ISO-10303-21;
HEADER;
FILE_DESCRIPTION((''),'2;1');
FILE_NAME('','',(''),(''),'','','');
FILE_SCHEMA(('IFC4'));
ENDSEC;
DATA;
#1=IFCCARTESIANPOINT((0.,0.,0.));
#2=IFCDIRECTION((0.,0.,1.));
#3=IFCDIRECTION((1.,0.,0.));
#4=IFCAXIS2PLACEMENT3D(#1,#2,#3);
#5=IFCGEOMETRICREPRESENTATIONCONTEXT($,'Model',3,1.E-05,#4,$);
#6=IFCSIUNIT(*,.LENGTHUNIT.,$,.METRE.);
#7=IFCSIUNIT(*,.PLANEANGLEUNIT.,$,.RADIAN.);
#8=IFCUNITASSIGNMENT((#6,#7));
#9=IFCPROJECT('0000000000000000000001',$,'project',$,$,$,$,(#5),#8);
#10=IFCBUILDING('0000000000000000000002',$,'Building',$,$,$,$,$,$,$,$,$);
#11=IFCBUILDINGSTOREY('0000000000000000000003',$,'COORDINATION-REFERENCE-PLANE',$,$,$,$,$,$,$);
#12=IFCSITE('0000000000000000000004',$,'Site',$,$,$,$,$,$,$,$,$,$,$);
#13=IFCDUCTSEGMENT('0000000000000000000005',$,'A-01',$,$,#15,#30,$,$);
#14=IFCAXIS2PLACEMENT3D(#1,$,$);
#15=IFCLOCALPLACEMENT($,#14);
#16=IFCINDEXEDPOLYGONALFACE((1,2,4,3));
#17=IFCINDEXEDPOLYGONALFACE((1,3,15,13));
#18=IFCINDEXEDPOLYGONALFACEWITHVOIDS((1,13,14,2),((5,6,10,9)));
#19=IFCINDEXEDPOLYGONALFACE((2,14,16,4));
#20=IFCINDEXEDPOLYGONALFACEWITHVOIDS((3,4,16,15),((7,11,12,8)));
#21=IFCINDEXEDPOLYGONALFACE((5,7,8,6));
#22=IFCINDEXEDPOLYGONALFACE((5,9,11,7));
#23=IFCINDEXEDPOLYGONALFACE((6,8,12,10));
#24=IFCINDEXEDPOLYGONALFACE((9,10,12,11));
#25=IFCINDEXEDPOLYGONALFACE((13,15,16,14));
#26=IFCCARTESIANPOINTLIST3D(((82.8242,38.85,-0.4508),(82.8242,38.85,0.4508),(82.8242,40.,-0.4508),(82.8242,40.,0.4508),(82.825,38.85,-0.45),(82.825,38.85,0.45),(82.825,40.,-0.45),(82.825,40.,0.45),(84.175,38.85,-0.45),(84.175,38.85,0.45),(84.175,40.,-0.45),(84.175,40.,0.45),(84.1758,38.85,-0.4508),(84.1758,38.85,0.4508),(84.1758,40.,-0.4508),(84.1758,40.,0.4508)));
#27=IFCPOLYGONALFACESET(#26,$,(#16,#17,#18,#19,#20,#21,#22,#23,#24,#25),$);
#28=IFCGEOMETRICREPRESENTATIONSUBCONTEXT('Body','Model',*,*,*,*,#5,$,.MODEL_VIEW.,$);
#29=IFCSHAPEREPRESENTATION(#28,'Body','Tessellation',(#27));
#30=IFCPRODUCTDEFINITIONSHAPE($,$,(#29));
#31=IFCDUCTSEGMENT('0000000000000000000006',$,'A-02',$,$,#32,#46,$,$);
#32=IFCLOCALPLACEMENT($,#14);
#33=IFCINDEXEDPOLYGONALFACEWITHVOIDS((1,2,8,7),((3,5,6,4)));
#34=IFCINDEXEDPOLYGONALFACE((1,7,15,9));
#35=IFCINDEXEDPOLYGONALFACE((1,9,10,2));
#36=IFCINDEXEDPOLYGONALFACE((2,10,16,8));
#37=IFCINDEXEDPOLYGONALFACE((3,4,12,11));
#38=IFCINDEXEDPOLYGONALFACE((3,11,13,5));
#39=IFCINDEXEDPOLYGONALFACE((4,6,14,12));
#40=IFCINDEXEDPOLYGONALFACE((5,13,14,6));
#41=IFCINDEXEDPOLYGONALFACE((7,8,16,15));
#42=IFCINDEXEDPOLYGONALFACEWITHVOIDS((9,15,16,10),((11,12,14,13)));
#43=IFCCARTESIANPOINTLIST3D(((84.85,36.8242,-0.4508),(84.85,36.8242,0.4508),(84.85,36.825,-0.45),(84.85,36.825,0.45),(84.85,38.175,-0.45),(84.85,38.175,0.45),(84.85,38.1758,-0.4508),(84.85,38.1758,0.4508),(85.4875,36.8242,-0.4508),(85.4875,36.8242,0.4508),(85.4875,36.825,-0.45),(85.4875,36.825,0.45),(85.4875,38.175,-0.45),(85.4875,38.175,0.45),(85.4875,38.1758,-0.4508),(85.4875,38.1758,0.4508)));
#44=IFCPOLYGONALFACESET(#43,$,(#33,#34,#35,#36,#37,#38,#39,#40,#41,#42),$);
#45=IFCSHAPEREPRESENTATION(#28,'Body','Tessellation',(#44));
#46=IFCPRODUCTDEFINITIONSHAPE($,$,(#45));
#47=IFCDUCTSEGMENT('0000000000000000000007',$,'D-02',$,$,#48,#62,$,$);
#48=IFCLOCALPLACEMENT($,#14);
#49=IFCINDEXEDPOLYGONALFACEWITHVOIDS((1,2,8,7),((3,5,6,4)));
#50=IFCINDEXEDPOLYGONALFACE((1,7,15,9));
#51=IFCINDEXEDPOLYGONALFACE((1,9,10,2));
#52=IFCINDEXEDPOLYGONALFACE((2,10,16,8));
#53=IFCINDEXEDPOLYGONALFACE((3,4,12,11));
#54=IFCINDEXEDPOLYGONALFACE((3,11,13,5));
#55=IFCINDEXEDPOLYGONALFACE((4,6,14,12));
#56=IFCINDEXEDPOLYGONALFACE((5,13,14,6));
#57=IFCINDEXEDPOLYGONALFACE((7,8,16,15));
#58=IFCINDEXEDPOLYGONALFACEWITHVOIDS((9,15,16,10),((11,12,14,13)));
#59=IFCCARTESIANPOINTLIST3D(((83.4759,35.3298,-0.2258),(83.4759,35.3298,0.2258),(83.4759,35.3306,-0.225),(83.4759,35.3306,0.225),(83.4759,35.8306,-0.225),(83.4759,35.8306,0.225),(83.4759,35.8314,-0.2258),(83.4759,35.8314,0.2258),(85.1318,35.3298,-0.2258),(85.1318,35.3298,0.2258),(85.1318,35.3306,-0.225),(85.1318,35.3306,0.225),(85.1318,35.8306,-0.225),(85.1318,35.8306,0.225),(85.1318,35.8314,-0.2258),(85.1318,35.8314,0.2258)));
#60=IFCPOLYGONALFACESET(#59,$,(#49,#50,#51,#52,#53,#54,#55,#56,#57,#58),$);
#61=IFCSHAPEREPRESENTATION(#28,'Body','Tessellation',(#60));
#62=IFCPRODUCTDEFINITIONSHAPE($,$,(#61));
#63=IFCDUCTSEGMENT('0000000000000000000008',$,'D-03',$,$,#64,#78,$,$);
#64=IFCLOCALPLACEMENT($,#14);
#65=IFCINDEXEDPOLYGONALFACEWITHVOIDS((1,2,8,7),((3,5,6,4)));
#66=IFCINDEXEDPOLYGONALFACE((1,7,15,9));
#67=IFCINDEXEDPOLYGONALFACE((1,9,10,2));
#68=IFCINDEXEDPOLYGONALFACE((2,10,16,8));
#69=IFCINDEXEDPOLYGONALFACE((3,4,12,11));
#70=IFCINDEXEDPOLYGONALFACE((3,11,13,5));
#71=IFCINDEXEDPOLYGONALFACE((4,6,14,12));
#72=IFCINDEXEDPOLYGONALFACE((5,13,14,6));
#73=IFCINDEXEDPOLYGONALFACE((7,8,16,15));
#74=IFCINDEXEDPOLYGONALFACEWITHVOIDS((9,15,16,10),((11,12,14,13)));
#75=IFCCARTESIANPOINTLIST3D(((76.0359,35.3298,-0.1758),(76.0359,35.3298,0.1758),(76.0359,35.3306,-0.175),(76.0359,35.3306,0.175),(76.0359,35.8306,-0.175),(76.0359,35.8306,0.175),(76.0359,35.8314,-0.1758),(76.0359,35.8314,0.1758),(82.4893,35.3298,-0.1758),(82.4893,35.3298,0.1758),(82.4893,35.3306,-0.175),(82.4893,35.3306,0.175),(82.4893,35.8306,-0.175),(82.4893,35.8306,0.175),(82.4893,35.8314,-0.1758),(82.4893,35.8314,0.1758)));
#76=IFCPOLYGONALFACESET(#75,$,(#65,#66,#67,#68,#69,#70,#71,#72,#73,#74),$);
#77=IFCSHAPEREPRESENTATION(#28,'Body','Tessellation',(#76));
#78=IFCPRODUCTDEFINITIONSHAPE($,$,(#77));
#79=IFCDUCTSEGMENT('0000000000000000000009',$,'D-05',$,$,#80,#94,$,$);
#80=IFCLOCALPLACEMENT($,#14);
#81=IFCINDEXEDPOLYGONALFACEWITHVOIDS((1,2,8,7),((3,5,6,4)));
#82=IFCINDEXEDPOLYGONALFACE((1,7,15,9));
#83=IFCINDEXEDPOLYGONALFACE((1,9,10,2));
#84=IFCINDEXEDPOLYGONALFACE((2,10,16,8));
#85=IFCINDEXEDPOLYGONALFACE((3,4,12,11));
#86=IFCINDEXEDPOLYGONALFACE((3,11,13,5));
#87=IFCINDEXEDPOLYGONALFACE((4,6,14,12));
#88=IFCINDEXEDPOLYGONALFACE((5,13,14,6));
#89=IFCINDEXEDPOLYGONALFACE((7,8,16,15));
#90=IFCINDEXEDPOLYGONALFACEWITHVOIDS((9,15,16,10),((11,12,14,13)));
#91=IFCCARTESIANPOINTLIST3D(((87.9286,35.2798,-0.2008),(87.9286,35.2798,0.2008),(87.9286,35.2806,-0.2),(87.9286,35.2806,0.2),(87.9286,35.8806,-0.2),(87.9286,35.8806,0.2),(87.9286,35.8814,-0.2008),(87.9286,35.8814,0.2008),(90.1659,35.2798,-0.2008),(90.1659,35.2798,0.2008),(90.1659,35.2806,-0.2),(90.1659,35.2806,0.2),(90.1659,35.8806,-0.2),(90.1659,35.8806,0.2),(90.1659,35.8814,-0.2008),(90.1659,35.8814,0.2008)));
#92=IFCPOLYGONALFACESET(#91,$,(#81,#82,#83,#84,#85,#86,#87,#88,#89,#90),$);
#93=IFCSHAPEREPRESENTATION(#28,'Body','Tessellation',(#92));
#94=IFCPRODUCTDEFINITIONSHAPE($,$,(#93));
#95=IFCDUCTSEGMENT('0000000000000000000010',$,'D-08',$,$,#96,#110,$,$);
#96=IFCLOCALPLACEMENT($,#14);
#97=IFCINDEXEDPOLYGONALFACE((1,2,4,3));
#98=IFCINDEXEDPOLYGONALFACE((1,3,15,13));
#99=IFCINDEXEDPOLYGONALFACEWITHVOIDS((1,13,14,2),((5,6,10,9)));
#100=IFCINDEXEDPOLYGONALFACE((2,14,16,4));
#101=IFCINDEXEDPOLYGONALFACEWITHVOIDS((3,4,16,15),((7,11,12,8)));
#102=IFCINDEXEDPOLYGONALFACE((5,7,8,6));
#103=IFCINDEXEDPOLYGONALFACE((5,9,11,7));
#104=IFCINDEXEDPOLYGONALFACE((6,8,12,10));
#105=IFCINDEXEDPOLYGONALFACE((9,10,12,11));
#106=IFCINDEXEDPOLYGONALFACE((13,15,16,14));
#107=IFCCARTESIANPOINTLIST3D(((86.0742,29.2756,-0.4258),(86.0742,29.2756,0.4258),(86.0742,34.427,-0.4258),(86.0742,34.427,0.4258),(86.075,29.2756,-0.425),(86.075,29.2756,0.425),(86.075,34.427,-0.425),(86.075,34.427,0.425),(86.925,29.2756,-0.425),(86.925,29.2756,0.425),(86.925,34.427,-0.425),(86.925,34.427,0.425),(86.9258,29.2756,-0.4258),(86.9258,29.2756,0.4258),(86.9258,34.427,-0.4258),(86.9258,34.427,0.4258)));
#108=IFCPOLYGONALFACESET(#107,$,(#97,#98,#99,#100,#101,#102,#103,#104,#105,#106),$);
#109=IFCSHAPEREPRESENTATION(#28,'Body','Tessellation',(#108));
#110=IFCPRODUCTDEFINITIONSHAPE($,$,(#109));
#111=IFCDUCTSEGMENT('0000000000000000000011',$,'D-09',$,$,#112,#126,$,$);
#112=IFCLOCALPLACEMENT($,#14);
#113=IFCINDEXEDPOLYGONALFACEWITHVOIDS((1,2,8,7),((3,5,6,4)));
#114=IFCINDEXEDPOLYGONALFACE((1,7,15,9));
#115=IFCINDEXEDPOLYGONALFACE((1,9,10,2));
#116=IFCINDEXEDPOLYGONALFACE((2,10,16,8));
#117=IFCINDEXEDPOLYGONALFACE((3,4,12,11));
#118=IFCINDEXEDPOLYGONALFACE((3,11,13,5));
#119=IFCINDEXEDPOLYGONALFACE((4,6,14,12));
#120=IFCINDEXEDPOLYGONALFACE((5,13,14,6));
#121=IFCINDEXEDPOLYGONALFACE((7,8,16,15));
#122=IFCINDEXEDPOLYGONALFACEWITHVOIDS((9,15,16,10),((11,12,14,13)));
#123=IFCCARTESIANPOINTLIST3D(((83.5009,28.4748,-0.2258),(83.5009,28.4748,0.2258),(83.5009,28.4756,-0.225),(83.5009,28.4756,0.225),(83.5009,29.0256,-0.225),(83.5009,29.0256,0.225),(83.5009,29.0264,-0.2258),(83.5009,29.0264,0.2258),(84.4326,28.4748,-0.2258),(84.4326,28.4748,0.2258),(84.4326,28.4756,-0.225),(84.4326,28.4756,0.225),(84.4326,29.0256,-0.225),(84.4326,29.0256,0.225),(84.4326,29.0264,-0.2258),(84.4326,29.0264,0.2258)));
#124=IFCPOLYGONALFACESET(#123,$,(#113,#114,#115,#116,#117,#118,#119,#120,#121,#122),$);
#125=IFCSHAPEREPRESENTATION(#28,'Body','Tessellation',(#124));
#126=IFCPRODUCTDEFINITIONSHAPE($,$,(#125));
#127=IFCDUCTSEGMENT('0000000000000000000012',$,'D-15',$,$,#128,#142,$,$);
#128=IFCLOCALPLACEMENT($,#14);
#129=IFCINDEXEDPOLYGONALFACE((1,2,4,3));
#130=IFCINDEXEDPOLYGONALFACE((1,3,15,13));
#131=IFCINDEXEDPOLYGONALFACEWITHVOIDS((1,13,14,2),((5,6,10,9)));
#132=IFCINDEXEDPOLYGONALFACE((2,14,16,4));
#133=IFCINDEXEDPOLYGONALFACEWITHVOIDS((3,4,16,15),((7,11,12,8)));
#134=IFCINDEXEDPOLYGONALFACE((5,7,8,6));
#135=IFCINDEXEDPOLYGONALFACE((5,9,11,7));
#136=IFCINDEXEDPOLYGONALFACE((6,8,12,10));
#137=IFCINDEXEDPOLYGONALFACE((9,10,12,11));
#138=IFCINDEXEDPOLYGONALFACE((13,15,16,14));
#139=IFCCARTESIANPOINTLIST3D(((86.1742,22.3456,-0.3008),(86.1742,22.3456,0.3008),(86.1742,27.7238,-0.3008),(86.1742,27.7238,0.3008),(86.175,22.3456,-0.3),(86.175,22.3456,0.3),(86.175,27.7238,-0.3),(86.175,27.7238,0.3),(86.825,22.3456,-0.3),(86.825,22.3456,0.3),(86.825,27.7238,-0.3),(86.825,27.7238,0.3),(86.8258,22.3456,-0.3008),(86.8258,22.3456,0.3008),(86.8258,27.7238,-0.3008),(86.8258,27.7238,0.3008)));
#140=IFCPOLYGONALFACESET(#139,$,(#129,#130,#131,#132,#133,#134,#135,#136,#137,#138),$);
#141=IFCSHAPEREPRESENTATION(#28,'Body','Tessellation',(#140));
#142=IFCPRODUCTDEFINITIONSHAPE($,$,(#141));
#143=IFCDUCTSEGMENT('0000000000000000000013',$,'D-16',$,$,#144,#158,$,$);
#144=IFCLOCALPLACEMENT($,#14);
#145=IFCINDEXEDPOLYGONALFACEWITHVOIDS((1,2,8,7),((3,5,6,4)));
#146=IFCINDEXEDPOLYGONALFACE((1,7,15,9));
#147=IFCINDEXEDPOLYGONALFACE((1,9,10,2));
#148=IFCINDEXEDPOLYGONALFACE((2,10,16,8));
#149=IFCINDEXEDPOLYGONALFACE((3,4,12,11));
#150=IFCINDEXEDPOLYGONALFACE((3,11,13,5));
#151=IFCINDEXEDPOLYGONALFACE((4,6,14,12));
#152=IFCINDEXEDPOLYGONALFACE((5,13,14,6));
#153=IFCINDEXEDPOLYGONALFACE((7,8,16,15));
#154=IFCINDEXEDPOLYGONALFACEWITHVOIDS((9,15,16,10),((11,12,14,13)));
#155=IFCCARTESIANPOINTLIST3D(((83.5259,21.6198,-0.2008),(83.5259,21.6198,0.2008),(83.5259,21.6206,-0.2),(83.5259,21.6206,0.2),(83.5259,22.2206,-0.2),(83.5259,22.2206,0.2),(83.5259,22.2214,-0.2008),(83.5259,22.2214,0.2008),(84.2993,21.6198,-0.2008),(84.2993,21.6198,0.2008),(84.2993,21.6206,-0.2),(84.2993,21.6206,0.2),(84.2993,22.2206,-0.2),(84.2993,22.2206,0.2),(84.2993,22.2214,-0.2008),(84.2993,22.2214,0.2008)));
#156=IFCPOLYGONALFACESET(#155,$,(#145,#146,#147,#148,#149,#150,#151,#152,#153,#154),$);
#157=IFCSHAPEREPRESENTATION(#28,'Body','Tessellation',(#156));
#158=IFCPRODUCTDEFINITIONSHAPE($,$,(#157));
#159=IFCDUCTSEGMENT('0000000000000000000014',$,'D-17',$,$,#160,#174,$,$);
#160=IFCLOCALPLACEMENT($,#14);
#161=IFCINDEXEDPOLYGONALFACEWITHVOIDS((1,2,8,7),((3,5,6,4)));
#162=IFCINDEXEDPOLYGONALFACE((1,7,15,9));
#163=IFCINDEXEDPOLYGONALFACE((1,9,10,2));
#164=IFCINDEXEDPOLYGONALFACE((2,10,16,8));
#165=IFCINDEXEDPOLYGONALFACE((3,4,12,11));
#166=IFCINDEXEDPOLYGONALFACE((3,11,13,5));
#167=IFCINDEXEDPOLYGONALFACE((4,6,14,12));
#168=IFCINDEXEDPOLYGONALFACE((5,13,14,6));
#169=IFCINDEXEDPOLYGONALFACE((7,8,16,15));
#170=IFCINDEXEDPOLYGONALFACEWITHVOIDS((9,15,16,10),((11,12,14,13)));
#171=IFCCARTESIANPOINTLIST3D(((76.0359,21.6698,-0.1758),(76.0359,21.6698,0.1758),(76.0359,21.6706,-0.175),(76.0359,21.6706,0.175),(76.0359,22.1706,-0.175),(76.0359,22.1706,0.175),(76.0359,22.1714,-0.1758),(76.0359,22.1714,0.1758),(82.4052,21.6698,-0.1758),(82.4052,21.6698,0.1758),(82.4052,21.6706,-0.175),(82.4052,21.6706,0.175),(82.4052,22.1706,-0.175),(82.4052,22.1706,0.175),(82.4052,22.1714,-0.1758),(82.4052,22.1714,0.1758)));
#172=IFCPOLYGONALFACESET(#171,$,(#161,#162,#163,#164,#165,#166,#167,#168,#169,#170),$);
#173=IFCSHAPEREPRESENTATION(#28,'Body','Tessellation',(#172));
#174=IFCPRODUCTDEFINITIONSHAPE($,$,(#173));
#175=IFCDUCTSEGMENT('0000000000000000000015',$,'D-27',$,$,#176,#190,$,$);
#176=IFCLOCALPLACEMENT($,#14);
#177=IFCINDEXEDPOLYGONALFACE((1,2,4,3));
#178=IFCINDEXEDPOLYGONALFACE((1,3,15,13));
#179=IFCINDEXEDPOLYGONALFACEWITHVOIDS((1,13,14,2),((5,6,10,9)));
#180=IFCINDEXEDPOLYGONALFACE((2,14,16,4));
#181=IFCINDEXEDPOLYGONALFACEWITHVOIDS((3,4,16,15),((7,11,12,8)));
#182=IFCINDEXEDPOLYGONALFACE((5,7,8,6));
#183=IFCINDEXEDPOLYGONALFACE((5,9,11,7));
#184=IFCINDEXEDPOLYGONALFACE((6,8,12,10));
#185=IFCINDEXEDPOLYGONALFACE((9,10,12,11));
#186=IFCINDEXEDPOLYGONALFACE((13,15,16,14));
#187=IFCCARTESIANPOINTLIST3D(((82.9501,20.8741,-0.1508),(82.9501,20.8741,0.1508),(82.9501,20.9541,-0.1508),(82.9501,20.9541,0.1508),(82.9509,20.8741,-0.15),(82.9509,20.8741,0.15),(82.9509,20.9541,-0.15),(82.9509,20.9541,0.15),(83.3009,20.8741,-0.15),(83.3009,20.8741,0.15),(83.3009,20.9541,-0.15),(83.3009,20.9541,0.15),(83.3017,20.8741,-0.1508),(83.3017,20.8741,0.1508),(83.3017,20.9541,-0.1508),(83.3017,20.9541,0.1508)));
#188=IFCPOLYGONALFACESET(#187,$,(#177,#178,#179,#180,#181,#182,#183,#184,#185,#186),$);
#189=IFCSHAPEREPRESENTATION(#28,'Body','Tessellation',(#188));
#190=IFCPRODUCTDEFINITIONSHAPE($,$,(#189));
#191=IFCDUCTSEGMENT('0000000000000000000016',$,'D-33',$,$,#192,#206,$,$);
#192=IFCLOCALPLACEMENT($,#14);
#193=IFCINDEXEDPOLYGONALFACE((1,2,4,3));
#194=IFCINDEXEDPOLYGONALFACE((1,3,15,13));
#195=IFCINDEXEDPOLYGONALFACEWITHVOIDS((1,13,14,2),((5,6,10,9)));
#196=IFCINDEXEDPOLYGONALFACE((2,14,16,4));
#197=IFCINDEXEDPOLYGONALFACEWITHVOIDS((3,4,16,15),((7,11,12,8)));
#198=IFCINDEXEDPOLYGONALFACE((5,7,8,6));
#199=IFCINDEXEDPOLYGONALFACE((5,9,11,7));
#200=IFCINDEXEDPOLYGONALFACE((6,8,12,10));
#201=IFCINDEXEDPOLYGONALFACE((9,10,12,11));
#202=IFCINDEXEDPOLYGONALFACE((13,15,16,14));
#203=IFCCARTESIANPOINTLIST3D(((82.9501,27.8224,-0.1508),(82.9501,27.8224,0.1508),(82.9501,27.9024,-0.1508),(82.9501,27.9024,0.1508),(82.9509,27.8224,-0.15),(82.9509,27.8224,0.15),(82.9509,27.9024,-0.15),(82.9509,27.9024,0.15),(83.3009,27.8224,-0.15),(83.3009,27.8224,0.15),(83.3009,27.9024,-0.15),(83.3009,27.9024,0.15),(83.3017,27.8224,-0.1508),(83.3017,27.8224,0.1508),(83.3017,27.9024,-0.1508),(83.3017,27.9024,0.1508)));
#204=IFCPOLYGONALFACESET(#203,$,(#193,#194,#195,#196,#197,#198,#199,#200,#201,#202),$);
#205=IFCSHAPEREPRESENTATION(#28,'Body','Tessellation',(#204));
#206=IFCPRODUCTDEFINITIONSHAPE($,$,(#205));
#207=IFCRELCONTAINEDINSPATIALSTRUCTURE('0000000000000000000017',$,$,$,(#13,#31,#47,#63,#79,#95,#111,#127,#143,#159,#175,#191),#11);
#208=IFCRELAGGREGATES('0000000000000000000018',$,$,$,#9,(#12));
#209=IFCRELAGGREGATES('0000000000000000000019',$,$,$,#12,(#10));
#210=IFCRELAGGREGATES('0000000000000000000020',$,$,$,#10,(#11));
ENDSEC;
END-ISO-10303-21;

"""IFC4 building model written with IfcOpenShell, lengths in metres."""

from ifc_helpers import new_model, si_unit, frame, origin, origin_with_axes, place, context, subcontext, project, spatial, hollow_rectangle, extrude, element, save


model = new_model("IFC4")

# Units and contexts
model_context = context("Model", 3, precision=1e-05, world=origin_with_axes())
body_context_1 = subcontext(model_context, "Body", "Model", "MODEL_VIEW")
ifc_project = project(units=[si_unit("LENGTHUNIT", "METRE"), si_unit("PLANEANGLEUNIT", "RADIAN")], contexts=[model_context])

# Site, building, storey
site = spatial("IfcSite", under=ifc_project, Name="Site")
building = spatial("IfcBuilding", under=site, Name="Building")
storey = spatial("IfcBuildingStorey", under=building, Name="COORDINATION-REFERENCE-PLANE")

# Duct segments
duct_segment_1_placement = place(None, frame((83.5, 38.85, 0.0), z_axis=(0.0, 1.0, 0.0), x_axis=(1.0, 0.0, 0.0)))
element("IfcDuctSegment", 1, at=duct_segment_1_placement, inside=storey, Name="A-01", context=body_context_1, shape_type="SweptSolid", body=[
    extrude(hollow_rectangle(XDim=1.3516, YDim=0.9016, WallThickness=0.0008), origin(), (0.0, 0.0, 1.0), 1.15),
])
duct_segment_2_placement = place(None, frame((84.85, 37.5, 0.0), z_axis=(1.0, 0.0, 0.0), x_axis=(0.0, 1.0, 0.0)))
element("IfcDuctSegment", 2, at=duct_segment_2_placement, inside=storey, Name="A-02", context=body_context_1, shape_type="SweptSolid", body=[
    extrude(hollow_rectangle(XDim=1.3516, YDim=0.9016, WallThickness=0.0008), origin(), (0.0, 0.0, 1.0), 0.6375),
])
duct_segment_3_placement = place(None, frame((83.4759, 35.5806, 0.0), z_axis=(1.0, 0.0, 0.0), x_axis=(0.0, 1.0, 0.0)))
element("IfcDuctSegment", 3, at=duct_segment_3_placement, inside=storey, Name="D-02", context=body_context_1, shape_type="SweptSolid", body=[
    extrude(hollow_rectangle(XDim=0.5016, YDim=0.4516, WallThickness=0.0008), origin(), (0.0, 0.0, 1.0), 1.6559),
])
duct_segment_4_placement = place(None, frame((76.0359, 35.5806, 0.0), z_axis=(1.0, 0.0, 0.0), x_axis=(0.0, 1.0, 0.0)))
element("IfcDuctSegment", 4, at=duct_segment_4_placement, inside=storey, Name="D-03", context=body_context_1, shape_type="SweptSolid", body=[
    extrude(hollow_rectangle(XDim=0.5016, YDim=0.3516, WallThickness=0.0008), origin(), (0.0, 0.0, 1.0), 6.4534),
])
duct_segment_5_placement = place(None, frame((87.9286, 35.5806, 0.0), z_axis=(1.0, 0.0, 0.0), x_axis=(0.0, 1.0, 0.0)))
element("IfcDuctSegment", 5, at=duct_segment_5_placement, inside=storey, Name="D-05", context=body_context_1, shape_type="SweptSolid", body=[
    extrude(hollow_rectangle(XDim=0.6016, YDim=0.4016, WallThickness=0.0008), origin(), (0.0, 0.0, 1.0), 2.2374),
])
duct_segment_6_placement = place(None, frame((86.5, 29.2756, 0.0), z_axis=(0.0, 1.0, 0.0), x_axis=(1.0, 0.0, 0.0)))
element("IfcDuctSegment", 6, at=duct_segment_6_placement, inside=storey, Name="D-08", context=body_context_1, shape_type="SweptSolid", body=[
    extrude(hollow_rectangle(XDim=0.8516, YDim=0.8516, WallThickness=0.0008), origin(), (0.0, 0.0, 1.0), 5.1514),
])
duct_segment_7_placement = place(None, frame((83.5009, 28.7506, 0.0), z_axis=(1.0, 0.0, 0.0), x_axis=(0.0, 1.0, 0.0)))
element("IfcDuctSegment", 7, at=duct_segment_7_placement, inside=storey, Name="D-09", context=body_context_1, shape_type="SweptSolid", body=[
    extrude(hollow_rectangle(XDim=0.5516, YDim=0.4516, WallThickness=0.0008), origin(), (0.0, 0.0, 1.0), 0.9316),
])
duct_segment_8_placement = place(None, frame((86.5, 22.3456, 0.0), z_axis=(0.0, 1.0, 0.0), x_axis=(1.0, 0.0, 0.0)))
element("IfcDuctSegment", 8, at=duct_segment_8_placement, inside=storey, Name="D-15", context=body_context_1, shape_type="SweptSolid", body=[
    extrude(hollow_rectangle(XDim=0.6516, YDim=0.6016, WallThickness=0.0008), origin(), (0.0, 0.0, 1.0), 5.3782),
])
duct_segment_9_placement = place(None, frame((83.5259, 21.9206, 0.0), z_axis=(1.0, 0.0, 0.0), x_axis=(0.0, 1.0, 0.0)))
element("IfcDuctSegment", 9, at=duct_segment_9_placement, inside=storey, Name="D-16", context=body_context_1, shape_type="SweptSolid", body=[
    extrude(hollow_rectangle(XDim=0.6016, YDim=0.4016, WallThickness=0.0008), origin(), (0.0, 0.0, 1.0), 0.7733),
])
duct_segment_10_placement = place(None, frame((76.0359, 21.9206, 0.0), z_axis=(1.0, 0.0, 0.0), x_axis=(0.0, 1.0, 0.0)))
element("IfcDuctSegment", 10, at=duct_segment_10_placement, inside=storey, Name="D-17", context=body_context_1, shape_type="SweptSolid", body=[
    extrude(hollow_rectangle(XDim=0.5016, YDim=0.3516, WallThickness=0.0008), origin(), (0.0, 0.0, 1.0), 6.3693),
])
for number, where, z_axis, x_axis, name in (
    (11, (83.1259, 20.8741, 0.0), (0.0, 1.0, 0.0), (1.0, 0.0, 0.0), "D-27"),
    (12, (83.1259, 27.8224, 0.0), (0.0, 1.0, 0.0), (1.0, 0.0, 0.0), "D-33"),
):
    element("IfcDuctSegment", number, at=place(None, frame(where, z_axis=z_axis, x_axis=x_axis)), inside=storey, Name=name, context=body_context_1, shape_type="SweptSolid", body=[
        extrude(hollow_rectangle(XDim=0.3516, YDim=0.3016, WallThickness=0.0008), origin(), (0.0, 0.0, 1.0), 0.08),
    ])

save(model, "model.ifc")
